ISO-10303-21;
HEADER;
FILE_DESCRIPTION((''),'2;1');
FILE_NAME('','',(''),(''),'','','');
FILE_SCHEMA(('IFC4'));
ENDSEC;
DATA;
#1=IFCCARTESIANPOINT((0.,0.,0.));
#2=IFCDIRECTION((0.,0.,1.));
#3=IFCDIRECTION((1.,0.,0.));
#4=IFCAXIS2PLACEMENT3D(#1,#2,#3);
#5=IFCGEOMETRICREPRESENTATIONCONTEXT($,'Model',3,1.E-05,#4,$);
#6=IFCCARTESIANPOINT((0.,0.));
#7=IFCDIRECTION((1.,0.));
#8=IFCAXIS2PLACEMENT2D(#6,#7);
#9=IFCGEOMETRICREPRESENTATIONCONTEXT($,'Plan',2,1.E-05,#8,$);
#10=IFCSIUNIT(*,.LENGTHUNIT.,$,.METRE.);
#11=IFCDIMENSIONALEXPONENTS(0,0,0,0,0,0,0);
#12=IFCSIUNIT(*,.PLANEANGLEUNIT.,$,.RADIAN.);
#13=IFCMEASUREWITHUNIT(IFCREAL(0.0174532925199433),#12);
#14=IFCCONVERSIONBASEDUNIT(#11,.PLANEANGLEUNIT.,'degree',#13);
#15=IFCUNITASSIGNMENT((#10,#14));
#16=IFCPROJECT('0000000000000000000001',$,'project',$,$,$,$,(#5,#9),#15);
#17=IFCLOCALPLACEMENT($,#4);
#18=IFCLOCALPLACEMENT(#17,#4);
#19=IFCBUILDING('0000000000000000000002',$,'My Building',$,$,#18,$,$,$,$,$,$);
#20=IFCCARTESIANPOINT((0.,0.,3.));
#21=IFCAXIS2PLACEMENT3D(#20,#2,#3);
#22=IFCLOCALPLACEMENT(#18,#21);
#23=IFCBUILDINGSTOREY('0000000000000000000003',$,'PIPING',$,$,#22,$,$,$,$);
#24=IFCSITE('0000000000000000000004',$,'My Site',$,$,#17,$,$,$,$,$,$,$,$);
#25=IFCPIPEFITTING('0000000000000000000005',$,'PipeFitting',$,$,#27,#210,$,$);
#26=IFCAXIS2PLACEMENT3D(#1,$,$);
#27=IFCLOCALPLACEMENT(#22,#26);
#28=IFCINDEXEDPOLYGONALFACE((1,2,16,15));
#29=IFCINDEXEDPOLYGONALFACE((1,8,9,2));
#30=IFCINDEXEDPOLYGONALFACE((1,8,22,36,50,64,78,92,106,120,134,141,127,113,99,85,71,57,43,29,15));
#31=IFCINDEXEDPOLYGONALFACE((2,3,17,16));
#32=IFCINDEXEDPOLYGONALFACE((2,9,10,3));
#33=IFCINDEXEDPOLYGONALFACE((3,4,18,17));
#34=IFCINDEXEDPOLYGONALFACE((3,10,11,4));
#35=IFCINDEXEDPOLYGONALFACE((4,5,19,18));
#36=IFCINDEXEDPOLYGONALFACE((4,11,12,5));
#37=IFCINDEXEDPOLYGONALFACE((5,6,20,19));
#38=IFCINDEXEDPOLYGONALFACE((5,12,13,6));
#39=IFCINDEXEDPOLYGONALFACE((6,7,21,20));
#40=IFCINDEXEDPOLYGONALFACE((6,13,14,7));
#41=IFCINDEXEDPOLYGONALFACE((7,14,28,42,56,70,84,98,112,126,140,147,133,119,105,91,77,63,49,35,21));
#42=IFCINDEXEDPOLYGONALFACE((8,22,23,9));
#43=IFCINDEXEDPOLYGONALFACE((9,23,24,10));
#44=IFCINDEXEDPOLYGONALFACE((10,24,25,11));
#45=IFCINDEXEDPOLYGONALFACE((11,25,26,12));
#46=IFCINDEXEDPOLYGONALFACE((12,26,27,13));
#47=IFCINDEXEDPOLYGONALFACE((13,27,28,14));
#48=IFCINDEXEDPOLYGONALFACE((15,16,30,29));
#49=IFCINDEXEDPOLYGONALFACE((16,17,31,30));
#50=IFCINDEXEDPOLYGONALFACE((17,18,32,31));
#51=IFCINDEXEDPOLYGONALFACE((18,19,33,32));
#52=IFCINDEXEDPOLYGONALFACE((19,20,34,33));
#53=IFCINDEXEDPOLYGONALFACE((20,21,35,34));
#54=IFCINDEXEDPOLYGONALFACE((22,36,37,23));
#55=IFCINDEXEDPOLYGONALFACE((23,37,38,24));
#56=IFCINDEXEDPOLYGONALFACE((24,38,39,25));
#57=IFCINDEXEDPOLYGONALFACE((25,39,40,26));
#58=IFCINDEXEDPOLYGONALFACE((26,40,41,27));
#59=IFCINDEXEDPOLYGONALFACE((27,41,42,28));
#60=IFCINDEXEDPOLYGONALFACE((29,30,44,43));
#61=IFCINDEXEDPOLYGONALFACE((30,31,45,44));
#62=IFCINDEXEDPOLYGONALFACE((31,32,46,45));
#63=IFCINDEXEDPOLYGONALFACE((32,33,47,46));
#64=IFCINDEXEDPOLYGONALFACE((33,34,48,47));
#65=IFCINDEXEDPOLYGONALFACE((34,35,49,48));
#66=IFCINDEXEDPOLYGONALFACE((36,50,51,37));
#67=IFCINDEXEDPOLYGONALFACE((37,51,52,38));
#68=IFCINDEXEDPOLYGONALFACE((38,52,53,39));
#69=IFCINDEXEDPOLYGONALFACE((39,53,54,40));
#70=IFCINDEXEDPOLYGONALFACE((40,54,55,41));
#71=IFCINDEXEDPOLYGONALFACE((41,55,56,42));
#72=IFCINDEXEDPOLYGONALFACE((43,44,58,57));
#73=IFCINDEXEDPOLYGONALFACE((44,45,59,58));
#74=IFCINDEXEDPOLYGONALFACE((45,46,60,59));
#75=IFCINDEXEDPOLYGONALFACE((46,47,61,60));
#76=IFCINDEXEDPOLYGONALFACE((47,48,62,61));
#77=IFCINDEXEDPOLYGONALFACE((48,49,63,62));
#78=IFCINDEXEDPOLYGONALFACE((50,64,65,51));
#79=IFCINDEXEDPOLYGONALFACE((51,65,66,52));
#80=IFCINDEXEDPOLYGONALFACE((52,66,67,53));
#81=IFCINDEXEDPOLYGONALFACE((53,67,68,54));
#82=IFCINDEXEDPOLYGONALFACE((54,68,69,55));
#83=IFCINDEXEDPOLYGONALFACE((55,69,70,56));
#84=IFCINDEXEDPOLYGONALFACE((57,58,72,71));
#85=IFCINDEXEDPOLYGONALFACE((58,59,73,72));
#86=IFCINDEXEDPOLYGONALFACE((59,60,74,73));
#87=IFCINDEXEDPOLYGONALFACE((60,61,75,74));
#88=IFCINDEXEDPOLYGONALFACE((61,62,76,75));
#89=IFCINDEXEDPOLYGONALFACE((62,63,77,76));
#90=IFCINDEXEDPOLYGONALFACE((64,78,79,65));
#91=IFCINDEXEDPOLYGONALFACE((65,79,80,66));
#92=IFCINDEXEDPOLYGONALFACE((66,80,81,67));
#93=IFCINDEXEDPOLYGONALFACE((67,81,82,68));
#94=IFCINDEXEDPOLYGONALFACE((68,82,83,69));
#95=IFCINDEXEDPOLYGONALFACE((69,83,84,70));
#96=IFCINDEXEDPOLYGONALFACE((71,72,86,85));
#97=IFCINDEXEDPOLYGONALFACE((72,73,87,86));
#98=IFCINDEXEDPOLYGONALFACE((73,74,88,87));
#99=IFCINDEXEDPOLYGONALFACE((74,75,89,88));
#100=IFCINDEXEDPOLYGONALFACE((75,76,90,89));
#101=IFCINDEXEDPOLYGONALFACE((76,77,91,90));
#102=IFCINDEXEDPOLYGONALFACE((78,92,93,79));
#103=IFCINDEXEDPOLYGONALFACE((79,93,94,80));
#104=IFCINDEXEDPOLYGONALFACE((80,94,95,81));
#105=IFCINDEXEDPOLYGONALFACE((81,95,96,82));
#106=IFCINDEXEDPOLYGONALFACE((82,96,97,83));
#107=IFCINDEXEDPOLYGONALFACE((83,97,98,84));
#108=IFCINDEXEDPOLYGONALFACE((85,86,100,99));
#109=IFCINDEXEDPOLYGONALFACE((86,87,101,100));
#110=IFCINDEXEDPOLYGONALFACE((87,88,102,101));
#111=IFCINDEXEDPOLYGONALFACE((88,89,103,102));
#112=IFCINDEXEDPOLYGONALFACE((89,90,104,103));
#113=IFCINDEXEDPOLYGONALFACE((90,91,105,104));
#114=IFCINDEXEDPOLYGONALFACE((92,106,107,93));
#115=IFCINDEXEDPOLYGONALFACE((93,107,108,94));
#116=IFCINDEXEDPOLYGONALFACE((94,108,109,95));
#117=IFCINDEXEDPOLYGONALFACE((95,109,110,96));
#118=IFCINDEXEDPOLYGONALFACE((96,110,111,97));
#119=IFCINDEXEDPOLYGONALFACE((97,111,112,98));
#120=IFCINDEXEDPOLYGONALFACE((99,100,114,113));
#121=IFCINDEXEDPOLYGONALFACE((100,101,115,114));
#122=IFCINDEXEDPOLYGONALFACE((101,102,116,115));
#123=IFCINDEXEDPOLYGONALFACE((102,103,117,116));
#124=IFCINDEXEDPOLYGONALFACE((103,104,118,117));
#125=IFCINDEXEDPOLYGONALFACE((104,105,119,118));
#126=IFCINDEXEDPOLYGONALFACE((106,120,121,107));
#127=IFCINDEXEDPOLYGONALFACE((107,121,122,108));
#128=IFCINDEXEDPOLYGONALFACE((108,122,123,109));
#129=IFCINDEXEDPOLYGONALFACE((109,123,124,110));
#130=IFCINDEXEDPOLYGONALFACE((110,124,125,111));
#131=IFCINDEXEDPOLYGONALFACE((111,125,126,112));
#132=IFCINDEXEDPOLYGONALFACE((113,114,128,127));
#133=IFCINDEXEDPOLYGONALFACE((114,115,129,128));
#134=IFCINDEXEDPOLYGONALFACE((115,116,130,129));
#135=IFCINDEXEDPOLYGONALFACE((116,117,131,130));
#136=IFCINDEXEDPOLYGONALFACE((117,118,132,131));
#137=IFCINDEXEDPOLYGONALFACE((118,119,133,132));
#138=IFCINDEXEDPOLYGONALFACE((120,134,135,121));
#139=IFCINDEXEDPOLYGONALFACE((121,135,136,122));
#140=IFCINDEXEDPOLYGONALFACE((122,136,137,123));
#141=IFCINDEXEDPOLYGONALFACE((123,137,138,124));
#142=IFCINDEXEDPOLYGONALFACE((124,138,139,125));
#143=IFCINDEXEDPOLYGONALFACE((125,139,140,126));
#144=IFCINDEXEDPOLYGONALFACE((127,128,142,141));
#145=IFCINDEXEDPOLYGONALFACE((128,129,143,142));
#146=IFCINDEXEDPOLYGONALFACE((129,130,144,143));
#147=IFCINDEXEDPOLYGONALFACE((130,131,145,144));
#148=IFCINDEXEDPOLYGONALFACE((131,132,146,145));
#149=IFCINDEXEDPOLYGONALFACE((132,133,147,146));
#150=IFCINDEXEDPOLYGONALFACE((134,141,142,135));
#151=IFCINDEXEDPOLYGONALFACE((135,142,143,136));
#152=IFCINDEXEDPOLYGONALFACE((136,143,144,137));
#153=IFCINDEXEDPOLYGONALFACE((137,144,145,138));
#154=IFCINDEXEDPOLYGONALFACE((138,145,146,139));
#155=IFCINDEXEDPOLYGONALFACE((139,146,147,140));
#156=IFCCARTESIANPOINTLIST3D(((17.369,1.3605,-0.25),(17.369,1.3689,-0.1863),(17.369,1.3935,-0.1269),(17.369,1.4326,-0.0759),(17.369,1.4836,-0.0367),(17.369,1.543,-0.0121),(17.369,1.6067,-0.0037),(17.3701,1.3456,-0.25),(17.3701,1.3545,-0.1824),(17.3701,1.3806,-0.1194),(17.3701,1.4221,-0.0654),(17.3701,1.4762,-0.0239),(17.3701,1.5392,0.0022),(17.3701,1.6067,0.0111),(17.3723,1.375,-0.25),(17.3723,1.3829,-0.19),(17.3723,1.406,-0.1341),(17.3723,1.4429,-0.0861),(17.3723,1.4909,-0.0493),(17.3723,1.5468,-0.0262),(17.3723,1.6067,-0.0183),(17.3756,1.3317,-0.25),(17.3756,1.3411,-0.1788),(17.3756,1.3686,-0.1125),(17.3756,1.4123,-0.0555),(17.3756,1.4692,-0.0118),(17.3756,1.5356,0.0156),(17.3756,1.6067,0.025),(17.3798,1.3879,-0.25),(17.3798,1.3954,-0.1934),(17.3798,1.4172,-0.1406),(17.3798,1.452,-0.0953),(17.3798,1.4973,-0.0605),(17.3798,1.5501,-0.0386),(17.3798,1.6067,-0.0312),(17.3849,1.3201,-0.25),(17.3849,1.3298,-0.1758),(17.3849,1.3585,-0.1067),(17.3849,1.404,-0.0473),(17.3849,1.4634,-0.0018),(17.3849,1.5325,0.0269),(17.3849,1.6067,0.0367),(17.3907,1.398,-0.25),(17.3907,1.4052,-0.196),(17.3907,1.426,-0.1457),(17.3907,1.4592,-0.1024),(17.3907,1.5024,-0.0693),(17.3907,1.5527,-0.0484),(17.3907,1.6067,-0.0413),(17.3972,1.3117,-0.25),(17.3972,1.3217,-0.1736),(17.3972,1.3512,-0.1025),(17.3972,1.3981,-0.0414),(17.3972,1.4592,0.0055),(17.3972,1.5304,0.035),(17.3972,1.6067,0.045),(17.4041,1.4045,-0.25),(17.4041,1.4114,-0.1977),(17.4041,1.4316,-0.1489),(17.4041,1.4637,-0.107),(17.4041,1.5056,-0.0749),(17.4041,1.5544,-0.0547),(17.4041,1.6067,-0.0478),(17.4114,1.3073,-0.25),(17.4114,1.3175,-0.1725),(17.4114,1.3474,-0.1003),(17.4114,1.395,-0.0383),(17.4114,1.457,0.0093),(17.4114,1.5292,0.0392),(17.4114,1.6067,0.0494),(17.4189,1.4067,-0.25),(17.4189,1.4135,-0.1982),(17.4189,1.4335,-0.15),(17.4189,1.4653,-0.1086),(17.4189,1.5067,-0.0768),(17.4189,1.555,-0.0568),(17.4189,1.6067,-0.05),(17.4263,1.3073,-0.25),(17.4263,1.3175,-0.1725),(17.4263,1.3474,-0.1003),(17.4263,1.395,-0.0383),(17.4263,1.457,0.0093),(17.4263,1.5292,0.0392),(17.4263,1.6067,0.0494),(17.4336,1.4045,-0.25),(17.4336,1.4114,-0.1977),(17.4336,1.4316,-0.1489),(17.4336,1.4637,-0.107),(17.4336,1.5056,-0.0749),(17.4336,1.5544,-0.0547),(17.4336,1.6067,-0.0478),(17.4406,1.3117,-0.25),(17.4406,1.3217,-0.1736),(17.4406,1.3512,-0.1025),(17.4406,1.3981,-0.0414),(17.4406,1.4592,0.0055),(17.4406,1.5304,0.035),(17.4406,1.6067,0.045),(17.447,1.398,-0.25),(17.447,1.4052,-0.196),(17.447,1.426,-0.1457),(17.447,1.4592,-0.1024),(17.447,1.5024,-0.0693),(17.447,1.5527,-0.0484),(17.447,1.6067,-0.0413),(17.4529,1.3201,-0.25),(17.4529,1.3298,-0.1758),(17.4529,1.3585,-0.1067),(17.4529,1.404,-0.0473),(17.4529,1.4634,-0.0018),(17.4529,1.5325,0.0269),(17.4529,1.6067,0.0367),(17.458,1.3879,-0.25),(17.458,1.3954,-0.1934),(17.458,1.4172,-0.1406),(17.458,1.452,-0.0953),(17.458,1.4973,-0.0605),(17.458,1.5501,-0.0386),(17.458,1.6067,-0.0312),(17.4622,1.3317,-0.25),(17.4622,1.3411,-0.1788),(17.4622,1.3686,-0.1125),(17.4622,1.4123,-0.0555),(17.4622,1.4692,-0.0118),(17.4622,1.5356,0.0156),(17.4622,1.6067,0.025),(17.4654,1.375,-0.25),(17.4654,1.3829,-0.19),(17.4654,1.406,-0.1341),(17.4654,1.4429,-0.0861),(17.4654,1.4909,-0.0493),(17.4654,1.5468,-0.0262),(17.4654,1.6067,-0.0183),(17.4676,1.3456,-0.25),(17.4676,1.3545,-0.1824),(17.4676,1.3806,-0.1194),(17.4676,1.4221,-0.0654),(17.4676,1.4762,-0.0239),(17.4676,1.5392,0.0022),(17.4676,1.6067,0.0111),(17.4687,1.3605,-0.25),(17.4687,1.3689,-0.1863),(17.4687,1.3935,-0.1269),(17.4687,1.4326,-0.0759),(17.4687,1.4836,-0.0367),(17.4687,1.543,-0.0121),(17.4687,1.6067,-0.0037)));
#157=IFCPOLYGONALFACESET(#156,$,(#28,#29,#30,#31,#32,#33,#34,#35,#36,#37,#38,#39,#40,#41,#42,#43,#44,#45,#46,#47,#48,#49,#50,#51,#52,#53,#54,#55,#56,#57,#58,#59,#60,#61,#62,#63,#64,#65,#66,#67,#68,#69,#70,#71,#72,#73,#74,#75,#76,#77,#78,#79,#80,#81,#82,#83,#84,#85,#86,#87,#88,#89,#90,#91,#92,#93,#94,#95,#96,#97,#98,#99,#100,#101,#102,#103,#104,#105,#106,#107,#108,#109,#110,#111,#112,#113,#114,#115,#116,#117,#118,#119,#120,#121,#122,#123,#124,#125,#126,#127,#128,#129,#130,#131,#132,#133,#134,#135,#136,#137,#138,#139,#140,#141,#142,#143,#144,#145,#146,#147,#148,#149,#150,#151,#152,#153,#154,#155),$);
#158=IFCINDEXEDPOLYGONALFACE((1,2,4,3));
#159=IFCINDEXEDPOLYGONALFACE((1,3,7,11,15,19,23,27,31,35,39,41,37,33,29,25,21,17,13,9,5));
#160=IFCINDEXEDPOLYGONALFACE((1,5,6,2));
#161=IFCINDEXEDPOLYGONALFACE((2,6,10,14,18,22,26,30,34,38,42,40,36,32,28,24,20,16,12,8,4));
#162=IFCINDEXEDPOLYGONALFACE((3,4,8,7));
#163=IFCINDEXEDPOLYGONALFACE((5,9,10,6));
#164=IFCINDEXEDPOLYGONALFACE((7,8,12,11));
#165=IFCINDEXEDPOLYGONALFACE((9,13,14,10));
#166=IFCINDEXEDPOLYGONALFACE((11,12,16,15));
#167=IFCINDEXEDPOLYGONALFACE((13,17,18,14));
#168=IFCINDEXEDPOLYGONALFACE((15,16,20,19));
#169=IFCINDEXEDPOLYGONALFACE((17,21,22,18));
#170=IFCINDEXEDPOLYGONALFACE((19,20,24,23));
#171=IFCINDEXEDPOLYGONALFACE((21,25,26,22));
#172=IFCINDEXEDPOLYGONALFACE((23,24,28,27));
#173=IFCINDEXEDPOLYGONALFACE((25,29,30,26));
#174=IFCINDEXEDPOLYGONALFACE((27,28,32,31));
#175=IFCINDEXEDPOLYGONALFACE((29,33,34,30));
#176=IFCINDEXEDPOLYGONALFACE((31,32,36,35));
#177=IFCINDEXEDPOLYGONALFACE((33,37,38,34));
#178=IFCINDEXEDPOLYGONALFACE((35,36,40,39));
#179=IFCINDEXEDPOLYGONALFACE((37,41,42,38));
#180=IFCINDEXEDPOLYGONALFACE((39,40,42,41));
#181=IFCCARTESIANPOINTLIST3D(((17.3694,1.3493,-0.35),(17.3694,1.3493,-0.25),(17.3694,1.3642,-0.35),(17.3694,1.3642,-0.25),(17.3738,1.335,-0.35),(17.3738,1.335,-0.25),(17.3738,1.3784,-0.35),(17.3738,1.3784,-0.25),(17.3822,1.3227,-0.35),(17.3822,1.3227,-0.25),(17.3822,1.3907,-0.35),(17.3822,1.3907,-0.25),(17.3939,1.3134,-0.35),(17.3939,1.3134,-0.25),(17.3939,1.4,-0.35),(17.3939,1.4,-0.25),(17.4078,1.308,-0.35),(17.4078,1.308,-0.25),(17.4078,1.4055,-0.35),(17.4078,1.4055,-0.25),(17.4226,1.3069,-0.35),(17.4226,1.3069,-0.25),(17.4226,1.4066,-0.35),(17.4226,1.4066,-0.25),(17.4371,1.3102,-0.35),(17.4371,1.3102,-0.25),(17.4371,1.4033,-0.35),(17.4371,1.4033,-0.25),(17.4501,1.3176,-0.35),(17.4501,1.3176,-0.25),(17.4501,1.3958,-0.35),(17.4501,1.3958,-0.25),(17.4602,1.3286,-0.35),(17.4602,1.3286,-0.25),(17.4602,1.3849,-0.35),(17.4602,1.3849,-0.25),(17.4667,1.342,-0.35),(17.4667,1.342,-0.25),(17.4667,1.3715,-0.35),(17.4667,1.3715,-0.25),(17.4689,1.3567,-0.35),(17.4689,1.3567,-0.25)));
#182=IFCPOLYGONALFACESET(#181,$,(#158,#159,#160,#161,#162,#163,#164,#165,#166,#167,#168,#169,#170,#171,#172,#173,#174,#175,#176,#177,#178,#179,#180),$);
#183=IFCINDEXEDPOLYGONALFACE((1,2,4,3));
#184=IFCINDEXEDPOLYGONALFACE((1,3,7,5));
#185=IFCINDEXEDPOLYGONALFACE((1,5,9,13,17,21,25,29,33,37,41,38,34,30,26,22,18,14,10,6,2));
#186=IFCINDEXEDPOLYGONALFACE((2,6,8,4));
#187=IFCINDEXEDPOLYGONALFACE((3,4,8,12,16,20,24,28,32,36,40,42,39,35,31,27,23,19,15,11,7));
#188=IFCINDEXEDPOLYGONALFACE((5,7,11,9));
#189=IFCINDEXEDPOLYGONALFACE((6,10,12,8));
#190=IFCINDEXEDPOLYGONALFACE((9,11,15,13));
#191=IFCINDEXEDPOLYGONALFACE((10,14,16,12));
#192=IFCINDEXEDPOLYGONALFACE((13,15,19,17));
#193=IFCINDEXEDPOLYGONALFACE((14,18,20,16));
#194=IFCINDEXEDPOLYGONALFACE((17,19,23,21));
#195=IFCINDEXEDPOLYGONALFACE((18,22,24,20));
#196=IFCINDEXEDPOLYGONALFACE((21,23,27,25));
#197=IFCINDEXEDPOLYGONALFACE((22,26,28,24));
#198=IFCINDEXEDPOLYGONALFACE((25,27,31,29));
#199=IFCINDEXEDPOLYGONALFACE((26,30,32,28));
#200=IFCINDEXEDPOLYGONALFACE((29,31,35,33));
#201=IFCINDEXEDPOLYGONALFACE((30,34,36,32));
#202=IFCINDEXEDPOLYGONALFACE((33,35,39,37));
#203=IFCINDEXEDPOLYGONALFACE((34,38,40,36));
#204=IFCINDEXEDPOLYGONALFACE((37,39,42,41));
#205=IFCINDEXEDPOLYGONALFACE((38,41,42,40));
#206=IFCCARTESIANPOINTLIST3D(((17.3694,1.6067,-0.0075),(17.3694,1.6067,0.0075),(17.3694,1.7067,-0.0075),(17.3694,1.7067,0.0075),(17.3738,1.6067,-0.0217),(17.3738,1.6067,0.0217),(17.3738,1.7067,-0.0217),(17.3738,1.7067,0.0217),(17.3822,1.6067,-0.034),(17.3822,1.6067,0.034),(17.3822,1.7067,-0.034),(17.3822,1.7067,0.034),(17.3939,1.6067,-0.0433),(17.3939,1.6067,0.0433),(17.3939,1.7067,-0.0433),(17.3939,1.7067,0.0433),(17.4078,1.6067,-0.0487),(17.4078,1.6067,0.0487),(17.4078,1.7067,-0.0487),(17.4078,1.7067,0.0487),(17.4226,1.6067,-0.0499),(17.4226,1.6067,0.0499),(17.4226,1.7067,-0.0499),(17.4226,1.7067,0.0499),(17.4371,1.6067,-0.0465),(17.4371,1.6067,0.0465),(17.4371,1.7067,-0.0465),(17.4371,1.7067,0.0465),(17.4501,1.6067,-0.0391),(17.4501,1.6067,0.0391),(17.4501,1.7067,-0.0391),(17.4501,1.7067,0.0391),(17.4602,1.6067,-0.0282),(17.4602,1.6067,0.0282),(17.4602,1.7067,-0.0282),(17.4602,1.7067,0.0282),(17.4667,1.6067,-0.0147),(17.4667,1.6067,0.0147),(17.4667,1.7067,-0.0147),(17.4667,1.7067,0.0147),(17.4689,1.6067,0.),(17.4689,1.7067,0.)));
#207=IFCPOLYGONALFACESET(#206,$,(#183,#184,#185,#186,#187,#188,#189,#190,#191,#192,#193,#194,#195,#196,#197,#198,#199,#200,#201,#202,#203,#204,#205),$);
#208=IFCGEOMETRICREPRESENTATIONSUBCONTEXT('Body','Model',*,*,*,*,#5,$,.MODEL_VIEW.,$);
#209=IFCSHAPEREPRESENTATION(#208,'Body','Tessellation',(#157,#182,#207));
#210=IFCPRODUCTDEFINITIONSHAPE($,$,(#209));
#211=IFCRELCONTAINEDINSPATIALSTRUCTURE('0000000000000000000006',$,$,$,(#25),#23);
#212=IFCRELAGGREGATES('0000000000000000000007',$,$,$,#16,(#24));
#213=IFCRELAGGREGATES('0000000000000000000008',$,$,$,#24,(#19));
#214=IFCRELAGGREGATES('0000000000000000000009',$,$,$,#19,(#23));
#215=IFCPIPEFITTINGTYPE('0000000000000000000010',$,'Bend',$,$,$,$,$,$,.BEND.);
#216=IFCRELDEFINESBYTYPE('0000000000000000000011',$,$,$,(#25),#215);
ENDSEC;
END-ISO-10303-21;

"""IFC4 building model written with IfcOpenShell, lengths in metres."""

from ifc_helpers import new_model, entity, si_unit, converted_unit, frame, origin_with_axes, origin_2d_with_axis, place, context, subcontext, project, spatial, circle, extrude, source, transform, mapped, type_object, type_shapes, element, save


model = new_model("IFC4")

# Units and contexts
model_context = context("Model", 3, precision=1e-05, world=origin_with_axes())
plan_context = context("Plan", 2, precision=1e-05, world=origin_2d_with_axis())
body_context = subcontext(model_context, "Body", "Model", "MODEL_VIEW")
ifc_project = project(units=[si_unit("LENGTHUNIT", "METRE"), converted_unit("PLANEANGLEUNIT", "degree", entity("IfcReal", 0.0174532925199433), si_unit("PLANEANGLEUNIT", "RADIAN"), dimensions=[0, 0, 0, 0, 0, 0, 0])], contexts=[model_context, plan_context])

# Site, building, storey
site_placement = place(None, origin_with_axes())
site = spatial("IfcSite", under=ifc_project, at=site_placement, Name="My Site")
building_placement = place(site_placement, origin_with_axes())
building = spatial("IfcBuilding", under=site, at=building_placement, Name="My Building")
storey_placement = place(building_placement, frame((0.0, 0.0, 3.0), z_axis=(0.0, 0.0, 1.0), x_axis=(1.0, 0.0, 0.0)))
storey = spatial("IfcBuildingStorey", under=building, at=storey_placement, Name="PIPING")

# Pipe fitting
pipe_fitting_type_1 = type_object("IfcPipeFittingType", Name="Bend", PredefinedType="BEND")
shared_shape = source(origin_with_axes(), body_context, "Body", "SolidModel", [
    entity("IfcSweptDiskSolid", entity("IfcIndexedPolyCurve", entity("IfcCartesianPointList3D", [[0.0, 0.0, -0.1], [0.0, -0.0732, -0.2768], [0.0, -0.25, -0.35]]), [entity("IfcArcIndex", [1, 2, 3])]), 0.05),
    extrude(circle(Radius=0.05), origin_with_axes(), (0.0, 0.0, -1.0), 0.1),
    extrude(circle(Radius=0.05), frame((0.0, -0.25, -0.35), z_axis=(0.0, -1.0, 0.0), x_axis=(1.0, 0.0, 0.0)), (0.0, 0.0, 1.0), 0.1),
])
type_shapes(pipe_fitting_type_1, [shared_shape])
for number, where, z_axis, x_axis, name in (
    (1, (17.4189, 1.3567, -0.35), (0.0, 0.0, -1.0), (1.0, 0.0, 0.0), "PipeFitting"),
):
    element("IfcPipeFitting", number, at=place(storey_placement, frame(where, z_axis=z_axis, x_axis=x_axis)), inside=storey, type_object=pipe_fitting_type_1, Name=name, context=body_context, shape_type="MappedRepresentation", body=[
        mapped(shared_shape, transform((0.0, 0.0, 0.0), x_axis=(1.0, 0.0, 0.0), y_axis=(0.0, 1.0, 0.0), z_axis=(0.0, 0.0, 1.0), scale=1.0)),
    ])

save(model, "model.ifc")
